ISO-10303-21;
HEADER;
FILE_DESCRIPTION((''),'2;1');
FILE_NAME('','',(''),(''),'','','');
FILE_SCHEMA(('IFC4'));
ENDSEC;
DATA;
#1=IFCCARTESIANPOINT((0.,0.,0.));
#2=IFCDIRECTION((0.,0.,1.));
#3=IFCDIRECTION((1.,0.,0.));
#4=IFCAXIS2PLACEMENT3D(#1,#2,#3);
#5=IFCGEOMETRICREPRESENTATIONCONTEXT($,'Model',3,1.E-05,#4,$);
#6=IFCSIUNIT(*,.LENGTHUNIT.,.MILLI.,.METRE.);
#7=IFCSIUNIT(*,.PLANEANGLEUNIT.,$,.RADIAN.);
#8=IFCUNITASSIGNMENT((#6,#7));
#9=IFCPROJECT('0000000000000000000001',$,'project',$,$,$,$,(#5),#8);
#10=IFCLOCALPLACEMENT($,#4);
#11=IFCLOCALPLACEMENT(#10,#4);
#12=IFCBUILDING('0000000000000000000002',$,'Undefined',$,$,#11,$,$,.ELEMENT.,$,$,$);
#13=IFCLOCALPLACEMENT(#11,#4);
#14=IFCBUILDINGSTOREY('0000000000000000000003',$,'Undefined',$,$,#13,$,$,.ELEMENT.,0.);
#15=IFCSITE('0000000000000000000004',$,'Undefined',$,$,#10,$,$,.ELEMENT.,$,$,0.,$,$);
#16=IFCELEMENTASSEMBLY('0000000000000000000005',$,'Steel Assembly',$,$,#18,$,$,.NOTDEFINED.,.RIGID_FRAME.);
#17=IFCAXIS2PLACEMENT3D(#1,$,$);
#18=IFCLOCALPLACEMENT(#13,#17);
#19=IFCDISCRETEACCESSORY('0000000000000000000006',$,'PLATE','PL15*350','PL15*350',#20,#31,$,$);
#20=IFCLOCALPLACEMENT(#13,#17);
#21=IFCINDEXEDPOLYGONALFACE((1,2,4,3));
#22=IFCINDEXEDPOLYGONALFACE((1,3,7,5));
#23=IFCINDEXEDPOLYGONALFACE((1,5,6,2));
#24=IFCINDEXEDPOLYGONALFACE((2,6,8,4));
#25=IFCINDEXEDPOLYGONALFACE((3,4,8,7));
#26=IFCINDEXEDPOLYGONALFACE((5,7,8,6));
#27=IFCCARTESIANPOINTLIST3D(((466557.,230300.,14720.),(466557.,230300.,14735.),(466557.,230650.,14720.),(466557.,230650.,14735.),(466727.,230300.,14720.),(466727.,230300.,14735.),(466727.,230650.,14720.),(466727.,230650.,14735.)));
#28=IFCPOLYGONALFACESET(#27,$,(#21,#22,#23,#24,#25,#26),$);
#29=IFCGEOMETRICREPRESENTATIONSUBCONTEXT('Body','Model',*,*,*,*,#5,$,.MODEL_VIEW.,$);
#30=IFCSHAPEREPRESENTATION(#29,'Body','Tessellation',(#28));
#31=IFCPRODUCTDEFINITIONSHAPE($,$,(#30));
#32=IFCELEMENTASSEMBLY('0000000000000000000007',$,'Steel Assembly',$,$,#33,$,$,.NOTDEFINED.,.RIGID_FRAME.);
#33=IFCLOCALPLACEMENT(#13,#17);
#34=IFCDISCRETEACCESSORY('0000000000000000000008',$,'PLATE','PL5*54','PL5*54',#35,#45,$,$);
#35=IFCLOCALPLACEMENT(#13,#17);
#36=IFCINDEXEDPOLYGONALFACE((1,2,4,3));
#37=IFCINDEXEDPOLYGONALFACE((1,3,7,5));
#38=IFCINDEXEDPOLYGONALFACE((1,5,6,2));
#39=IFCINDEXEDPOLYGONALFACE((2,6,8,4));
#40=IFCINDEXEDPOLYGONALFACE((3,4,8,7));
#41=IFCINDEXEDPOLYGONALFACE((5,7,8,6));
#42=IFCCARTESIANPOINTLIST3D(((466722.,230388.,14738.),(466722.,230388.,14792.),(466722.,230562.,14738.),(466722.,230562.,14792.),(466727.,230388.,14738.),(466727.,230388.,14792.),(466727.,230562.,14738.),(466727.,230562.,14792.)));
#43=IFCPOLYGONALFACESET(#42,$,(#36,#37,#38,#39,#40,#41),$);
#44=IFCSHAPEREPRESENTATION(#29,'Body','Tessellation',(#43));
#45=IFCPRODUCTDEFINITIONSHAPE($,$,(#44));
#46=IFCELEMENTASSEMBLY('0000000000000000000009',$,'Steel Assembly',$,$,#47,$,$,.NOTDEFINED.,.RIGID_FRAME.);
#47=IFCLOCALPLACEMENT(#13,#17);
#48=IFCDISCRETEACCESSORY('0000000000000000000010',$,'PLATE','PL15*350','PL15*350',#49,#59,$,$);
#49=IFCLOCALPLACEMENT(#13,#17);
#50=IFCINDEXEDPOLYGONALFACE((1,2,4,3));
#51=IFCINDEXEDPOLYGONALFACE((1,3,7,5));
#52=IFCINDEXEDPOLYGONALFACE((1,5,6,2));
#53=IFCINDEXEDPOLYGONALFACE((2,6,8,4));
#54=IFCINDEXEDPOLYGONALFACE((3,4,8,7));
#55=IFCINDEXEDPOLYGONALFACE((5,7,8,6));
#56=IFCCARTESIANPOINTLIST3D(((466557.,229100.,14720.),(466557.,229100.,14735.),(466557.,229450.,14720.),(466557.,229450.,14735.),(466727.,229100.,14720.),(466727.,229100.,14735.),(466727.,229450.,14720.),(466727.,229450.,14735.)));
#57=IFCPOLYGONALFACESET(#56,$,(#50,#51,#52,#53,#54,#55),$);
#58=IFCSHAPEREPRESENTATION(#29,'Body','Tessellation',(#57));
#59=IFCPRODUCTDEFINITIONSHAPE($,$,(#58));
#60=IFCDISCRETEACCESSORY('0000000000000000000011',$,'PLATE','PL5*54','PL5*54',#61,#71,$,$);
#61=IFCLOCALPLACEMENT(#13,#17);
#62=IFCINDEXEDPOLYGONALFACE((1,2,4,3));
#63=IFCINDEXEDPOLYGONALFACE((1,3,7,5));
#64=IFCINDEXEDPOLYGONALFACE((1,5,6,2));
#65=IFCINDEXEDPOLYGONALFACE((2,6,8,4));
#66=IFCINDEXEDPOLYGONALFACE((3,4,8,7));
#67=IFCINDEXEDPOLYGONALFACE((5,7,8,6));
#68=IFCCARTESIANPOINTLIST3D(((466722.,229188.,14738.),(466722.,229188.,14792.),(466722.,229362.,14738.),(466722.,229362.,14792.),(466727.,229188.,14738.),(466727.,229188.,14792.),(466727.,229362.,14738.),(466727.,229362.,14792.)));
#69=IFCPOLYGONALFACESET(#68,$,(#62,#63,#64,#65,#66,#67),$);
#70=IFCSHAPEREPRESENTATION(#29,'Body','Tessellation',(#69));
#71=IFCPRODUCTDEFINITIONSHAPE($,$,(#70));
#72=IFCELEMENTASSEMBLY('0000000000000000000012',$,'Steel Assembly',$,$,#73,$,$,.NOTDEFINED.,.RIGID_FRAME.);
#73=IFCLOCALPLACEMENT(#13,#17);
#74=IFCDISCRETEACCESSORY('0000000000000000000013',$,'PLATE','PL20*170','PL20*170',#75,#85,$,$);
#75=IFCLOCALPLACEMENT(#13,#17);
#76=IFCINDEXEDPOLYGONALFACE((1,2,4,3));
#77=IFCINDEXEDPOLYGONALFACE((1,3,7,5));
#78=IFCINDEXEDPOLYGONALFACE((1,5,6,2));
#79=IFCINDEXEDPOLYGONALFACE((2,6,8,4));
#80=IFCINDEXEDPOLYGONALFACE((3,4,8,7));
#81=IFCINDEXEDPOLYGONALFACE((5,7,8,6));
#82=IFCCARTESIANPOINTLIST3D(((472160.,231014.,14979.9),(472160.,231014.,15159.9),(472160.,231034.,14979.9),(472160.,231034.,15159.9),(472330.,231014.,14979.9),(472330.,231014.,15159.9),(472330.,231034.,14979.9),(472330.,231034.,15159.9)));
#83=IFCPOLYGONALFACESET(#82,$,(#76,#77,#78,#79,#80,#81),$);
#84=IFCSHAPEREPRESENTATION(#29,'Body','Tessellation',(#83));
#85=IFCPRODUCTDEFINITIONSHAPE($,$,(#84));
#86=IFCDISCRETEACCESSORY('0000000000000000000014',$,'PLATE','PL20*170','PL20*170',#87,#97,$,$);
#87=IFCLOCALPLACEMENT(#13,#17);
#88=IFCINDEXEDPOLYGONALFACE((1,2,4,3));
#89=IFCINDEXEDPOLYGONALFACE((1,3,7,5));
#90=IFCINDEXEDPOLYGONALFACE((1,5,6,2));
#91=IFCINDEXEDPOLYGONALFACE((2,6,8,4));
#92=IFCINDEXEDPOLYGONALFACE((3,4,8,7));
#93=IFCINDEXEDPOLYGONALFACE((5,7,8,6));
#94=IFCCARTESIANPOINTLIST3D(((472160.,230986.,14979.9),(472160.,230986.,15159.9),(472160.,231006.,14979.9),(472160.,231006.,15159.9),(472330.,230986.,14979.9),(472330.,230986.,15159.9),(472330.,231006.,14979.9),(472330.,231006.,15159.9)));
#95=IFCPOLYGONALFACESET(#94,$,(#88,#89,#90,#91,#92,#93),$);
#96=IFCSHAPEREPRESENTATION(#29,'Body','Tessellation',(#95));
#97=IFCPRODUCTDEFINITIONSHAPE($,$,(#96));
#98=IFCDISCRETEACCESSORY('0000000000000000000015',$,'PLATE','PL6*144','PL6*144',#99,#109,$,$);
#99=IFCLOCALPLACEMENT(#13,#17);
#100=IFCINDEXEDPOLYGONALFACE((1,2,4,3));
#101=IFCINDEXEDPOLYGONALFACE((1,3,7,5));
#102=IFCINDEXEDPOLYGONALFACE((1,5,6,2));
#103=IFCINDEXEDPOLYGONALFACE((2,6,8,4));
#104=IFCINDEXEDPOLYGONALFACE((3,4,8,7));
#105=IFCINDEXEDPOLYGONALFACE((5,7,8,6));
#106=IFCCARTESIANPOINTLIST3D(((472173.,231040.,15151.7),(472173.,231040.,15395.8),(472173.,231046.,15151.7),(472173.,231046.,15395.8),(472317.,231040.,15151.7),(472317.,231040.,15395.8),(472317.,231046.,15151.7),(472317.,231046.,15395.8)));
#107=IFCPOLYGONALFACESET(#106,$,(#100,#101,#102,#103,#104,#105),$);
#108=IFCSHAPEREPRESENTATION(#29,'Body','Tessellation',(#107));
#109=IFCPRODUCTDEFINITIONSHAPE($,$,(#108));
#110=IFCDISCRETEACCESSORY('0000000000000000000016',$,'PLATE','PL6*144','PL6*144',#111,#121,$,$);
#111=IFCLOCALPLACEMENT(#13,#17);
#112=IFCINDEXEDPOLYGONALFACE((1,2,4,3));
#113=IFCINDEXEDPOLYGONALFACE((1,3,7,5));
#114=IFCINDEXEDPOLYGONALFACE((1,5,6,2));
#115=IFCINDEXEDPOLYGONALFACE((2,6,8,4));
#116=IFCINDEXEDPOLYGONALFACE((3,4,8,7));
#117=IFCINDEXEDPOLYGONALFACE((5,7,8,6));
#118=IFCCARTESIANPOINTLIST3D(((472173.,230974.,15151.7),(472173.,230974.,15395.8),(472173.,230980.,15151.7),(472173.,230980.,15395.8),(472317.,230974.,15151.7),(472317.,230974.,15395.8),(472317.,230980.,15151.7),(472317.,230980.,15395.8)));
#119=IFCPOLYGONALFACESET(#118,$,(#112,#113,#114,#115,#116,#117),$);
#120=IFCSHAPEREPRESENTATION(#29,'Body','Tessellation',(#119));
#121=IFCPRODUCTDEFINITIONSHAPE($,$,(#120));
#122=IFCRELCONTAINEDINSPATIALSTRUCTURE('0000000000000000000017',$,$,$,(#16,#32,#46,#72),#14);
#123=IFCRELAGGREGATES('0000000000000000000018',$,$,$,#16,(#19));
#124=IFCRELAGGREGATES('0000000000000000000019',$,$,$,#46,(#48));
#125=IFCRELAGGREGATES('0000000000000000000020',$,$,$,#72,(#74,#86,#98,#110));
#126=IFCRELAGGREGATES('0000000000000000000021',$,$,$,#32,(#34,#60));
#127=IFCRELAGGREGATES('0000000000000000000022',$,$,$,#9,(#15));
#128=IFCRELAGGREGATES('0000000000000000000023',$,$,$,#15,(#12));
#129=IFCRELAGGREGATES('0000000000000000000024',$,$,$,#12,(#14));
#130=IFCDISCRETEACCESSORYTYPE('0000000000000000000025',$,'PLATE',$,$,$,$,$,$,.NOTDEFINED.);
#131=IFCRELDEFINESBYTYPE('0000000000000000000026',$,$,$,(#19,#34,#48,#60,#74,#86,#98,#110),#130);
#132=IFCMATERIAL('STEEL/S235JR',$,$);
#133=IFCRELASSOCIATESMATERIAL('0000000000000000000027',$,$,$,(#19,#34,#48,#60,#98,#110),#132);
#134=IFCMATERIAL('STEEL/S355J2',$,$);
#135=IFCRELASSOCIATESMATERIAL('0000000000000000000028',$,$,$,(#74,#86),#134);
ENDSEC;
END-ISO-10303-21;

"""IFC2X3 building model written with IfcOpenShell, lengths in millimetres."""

from ifc_helpers import new_model, si_unit, frame, origin_with_axes, origin_2d_with_axis, place, context, subcontext, project, spatial, polyline, rectangle, outline, extrude, material, type_object, element, aggregate, save


model = new_model("IFC2X3")

# Units and contexts
model_context = context("Model", 3, precision=1e-05, world=origin_with_axes())
body_context = subcontext(model_context, "Body", "Model", "MODEL_VIEW")
ifc_project = project(units=[si_unit("LENGTHUNIT", "METRE", prefix="MILLI"), si_unit("PLANEANGLEUNIT", "RADIAN")], contexts=[model_context])

# Site, building, storey
site_placement = place(None, origin_with_axes())
site = spatial("IfcSite", under=ifc_project, at=site_placement, Name="Undefined", CompositionType="ELEMENT", RefElevation=0.0)
building_placement = place(site_placement, origin_with_axes())
building = spatial("IfcBuilding", under=site, at=building_placement, Name="Undefined", CompositionType="ELEMENT")
storey_placement = place(building_placement, origin_with_axes())
storey = spatial("IfcBuildingStorey", under=building, at=storey_placement, Name="Undefined", CompositionType="ELEMENT", Elevation=0.0)

# Shared definitions
ifc_material_1 = material(Name="STEEL/S355J2")

# Element assemblies, discrete accessories
assembly_1_placement = place(storey_placement, origin_with_axes())
assembly_1 = element("IfcElementAssembly", 1, at=assembly_1_placement, inside=storey, Name="Steel Assembly", AssemblyPlace="NOTDEFINED", PredefinedType="RIGID_FRAME")
ifc_material_2 = material(Name="STEEL/S235JR")
discrete_accessory_type = type_object("IfcDiscreteAccessoryType", Name="PLATE")
discrete_accessory_1_placement = place(assembly_1_placement, frame((466727.0, 230475.0, 14727.5), z_axis=(0.0, 0.0, 1.0), x_axis=(-1.0, 0.0, 0.0)))
discrete_accessory_1 = element("IfcDiscreteAccessory", 2, at=discrete_accessory_1_placement, type_object=discrete_accessory_type, material=ifc_material_2, Name="PLATE", Description="PL15*350", ObjectType="PL15*350", context=body_context, shape_type="SweptSolid", body=[
    extrude(outline(polyline([(170.0, -175.0), (0.0, -175.0), (0.0, 175.0), (170.0, 175.0), (170.0, -175.0)])), frame((0.0, 0.0, -7.5), z_axis=(0.0, 0.0, 1.0), x_axis=(1.0, 0.0, 0.0)), (0.0, 0.0, 1.0), 15.0),
])
aggregate(assembly_1, [discrete_accessory_1])
assembly_2_placement = place(storey_placement, origin_with_axes())
assembly_2 = element("IfcElementAssembly", 3, at=assembly_2_placement, inside=storey, Name="Steel Assembly", AssemblyPlace="NOTDEFINED", PredefinedType="RIGID_FRAME")
discrete_accessory_2_placement = place(assembly_2_placement, frame((466724.5, 230388.0, 14765.0), z_axis=(-1.0, 0.0, 0.0), x_axis=(0.0, 1.0, 0.0)))
discrete_accessory_2 = element("IfcDiscreteAccessory", 4, at=discrete_accessory_2_placement, type_object=discrete_accessory_type, material=ifc_material_2, Name="PLATE", Description="PL5*54", ObjectType="PL5*54", context=body_context, shape_type="SweptSolid", body=[
    extrude(outline(polyline([(174.0, 27.0), (174.0, -27.0), (0.0, -27.0), (0.0, 27.0), (174.0, 27.0)])), frame((0.0, 0.0, -2.5), z_axis=(0.0, 0.0, 1.0), x_axis=(1.0, 0.0, 0.0)), (0.0, 0.0, 1.0), 5.0),
])
assembly_3_placement = place(storey_placement, origin_with_axes())
assembly_3 = element("IfcElementAssembly", 5, at=assembly_3_placement, inside=storey, Name="Steel Assembly", AssemblyPlace="NOTDEFINED", PredefinedType="RIGID_FRAME")
discrete_accessory_3_placement = place(assembly_3_placement, frame((466727.0, 229275.0, 14727.5), z_axis=(0.0, 0.0, 1.0), x_axis=(-1.0, 0.0, 0.0)))
discrete_accessory_3 = element("IfcDiscreteAccessory", 6, at=discrete_accessory_3_placement, type_object=discrete_accessory_type, material=ifc_material_2, Name="PLATE", Description="PL15*350", ObjectType="PL15*350", context=body_context, shape_type="SweptSolid", body=[
    extrude(outline(polyline([(170.0, -175.0), (0.0, -175.0), (0.0, 175.0), (170.0, 175.0), (170.0, -175.0)])), frame((0.0, 0.0, -7.5), z_axis=(0.0, 0.0, 1.0), x_axis=(1.0, 0.0, 0.0)), (0.0, 0.0, 1.0), 15.0),
])
aggregate(assembly_3, [discrete_accessory_3])

# Discrete accessory
discrete_accessory_4_placement = place(assembly_2_placement, frame((466724.5, 229188.0, 14765.0), z_axis=(-1.0, 0.0, 0.0), x_axis=(0.0, 1.0, 0.0)))
discrete_accessory_4 = element("IfcDiscreteAccessory", 7, at=discrete_accessory_4_placement, type_object=discrete_accessory_type, material=ifc_material_2, Name="PLATE", Description="PL5*54", ObjectType="PL5*54", context=body_context, shape_type="SweptSolid", body=[
    extrude(outline(polyline([(174.0, 27.0), (174.0, -27.0), (0.0, -27.0), (0.0, 27.0), (174.0, 27.0)])), frame((0.0, 0.0, -2.5), z_axis=(0.0, 0.0, 1.0), x_axis=(1.0, 0.0, 0.0)), (0.0, 0.0, 1.0), 5.0),
])

# Element assembly, discrete accessories
assembly_4_placement = place(storey_placement, origin_with_axes())
assembly_4 = element("IfcElementAssembly", 8, at=assembly_4_placement, inside=storey, Name="Steel Assembly", AssemblyPlace="NOTDEFINED", PredefinedType="RIGID_FRAME")
discrete_accessory_5_placement = place(assembly_4_placement, frame((472160.0, 231024.0, 14979.9), z_axis=(0.0, 1.0, 0.0), x_axis=(0.0, 0.0, 1.0)))
discrete_accessory_5 = element("IfcDiscreteAccessory", 9, at=discrete_accessory_5_placement, type_object=discrete_accessory_type, material=ifc_material_1, Name="PLATE", Description="PL20*170", ObjectType="PL20*170", context=body_context, shape_type="SweptSolid", body=[
    extrude(outline(polyline([(0.0, 0.0), (180.0, 0.0), (180.0, 170.0), (0.0, 170.0), (0.0, 0.0)])), frame((0.0, 0.0, -10.0), z_axis=(0.0, 0.0, 1.0), x_axis=(1.0, 0.0, 0.0)), (0.0, 0.0, 1.0), 20.0),
])
discrete_accessory_6_placement = place(assembly_4_placement, frame((472160.0, 230996.0, 14979.9), z_axis=(0.0, 1.0, 0.0), x_axis=(0.0, 0.0, 1.0)))
discrete_accessory_6 = element("IfcDiscreteAccessory", 10, at=discrete_accessory_6_placement, type_object=discrete_accessory_type, material=ifc_material_1, Name="PLATE", Description="PL20*170", ObjectType="PL20*170", context=body_context, shape_type="SweptSolid", body=[
    extrude(outline(polyline([(0.0, 0.0), (180.0, 0.0), (180.0, 170.0), (0.0, 170.0), (0.0, 0.0)])), frame((0.0, 0.0, -10.0), z_axis=(0.0, 0.0, 1.0), x_axis=(1.0, 0.0, 0.0)), (0.0, 0.0, 1.0), 20.0),
])
discrete_accessory_7_placement = place(assembly_4_placement, frame((472245.0, 231043.0, 15151.7), z_axis=(0.0, 0.0, 1.0), x_axis=(1.0, 0.0, 0.0)))
discrete_accessory_7 = element("IfcDiscreteAccessory", 11, at=discrete_accessory_7_placement, type_object=discrete_accessory_type, material=ifc_material_2, Name="PLATE", Description="PL6*144", ObjectType="PL6*144", context=body_context, shape_type="SweptSolid", body=[
    extrude(rectangle(XDim=6.0, YDim=144.0, at=origin_2d_with_axis()), frame((0.0, 0.0, 244.1), z_axis=(0.0, 0.0, -1.0), x_axis=(0.0, 1.0, 0.0)), (0.0, 0.0, 1.0), 244.1),
])
discrete_accessory_8_placement = place(assembly_4_placement, frame((472245.0, 230977.0, 15151.7), z_axis=(0.0, 0.0, 1.0), x_axis=(1.0, 0.0, 0.0)))
discrete_accessory_8 = element("IfcDiscreteAccessory", 12, at=discrete_accessory_8_placement, type_object=discrete_accessory_type, material=ifc_material_2, Name="PLATE", Description="PL6*144", ObjectType="PL6*144", context=body_context, shape_type="SweptSolid", body=[
    extrude(rectangle(XDim=6.0, YDim=144.0, at=origin_2d_with_axis()), frame((0.0, 0.0, 244.1), z_axis=(0.0, 0.0, -1.0), x_axis=(0.0, -1.0, 0.0)), (0.0, 0.0, 1.0), 244.1),
])
aggregate(assembly_4, [discrete_accessory_5, discrete_accessory_6, discrete_accessory_7, discrete_accessory_8])

aggregate(assembly_2, [discrete_accessory_2, discrete_accessory_4])

save(model, "model.ifc")
